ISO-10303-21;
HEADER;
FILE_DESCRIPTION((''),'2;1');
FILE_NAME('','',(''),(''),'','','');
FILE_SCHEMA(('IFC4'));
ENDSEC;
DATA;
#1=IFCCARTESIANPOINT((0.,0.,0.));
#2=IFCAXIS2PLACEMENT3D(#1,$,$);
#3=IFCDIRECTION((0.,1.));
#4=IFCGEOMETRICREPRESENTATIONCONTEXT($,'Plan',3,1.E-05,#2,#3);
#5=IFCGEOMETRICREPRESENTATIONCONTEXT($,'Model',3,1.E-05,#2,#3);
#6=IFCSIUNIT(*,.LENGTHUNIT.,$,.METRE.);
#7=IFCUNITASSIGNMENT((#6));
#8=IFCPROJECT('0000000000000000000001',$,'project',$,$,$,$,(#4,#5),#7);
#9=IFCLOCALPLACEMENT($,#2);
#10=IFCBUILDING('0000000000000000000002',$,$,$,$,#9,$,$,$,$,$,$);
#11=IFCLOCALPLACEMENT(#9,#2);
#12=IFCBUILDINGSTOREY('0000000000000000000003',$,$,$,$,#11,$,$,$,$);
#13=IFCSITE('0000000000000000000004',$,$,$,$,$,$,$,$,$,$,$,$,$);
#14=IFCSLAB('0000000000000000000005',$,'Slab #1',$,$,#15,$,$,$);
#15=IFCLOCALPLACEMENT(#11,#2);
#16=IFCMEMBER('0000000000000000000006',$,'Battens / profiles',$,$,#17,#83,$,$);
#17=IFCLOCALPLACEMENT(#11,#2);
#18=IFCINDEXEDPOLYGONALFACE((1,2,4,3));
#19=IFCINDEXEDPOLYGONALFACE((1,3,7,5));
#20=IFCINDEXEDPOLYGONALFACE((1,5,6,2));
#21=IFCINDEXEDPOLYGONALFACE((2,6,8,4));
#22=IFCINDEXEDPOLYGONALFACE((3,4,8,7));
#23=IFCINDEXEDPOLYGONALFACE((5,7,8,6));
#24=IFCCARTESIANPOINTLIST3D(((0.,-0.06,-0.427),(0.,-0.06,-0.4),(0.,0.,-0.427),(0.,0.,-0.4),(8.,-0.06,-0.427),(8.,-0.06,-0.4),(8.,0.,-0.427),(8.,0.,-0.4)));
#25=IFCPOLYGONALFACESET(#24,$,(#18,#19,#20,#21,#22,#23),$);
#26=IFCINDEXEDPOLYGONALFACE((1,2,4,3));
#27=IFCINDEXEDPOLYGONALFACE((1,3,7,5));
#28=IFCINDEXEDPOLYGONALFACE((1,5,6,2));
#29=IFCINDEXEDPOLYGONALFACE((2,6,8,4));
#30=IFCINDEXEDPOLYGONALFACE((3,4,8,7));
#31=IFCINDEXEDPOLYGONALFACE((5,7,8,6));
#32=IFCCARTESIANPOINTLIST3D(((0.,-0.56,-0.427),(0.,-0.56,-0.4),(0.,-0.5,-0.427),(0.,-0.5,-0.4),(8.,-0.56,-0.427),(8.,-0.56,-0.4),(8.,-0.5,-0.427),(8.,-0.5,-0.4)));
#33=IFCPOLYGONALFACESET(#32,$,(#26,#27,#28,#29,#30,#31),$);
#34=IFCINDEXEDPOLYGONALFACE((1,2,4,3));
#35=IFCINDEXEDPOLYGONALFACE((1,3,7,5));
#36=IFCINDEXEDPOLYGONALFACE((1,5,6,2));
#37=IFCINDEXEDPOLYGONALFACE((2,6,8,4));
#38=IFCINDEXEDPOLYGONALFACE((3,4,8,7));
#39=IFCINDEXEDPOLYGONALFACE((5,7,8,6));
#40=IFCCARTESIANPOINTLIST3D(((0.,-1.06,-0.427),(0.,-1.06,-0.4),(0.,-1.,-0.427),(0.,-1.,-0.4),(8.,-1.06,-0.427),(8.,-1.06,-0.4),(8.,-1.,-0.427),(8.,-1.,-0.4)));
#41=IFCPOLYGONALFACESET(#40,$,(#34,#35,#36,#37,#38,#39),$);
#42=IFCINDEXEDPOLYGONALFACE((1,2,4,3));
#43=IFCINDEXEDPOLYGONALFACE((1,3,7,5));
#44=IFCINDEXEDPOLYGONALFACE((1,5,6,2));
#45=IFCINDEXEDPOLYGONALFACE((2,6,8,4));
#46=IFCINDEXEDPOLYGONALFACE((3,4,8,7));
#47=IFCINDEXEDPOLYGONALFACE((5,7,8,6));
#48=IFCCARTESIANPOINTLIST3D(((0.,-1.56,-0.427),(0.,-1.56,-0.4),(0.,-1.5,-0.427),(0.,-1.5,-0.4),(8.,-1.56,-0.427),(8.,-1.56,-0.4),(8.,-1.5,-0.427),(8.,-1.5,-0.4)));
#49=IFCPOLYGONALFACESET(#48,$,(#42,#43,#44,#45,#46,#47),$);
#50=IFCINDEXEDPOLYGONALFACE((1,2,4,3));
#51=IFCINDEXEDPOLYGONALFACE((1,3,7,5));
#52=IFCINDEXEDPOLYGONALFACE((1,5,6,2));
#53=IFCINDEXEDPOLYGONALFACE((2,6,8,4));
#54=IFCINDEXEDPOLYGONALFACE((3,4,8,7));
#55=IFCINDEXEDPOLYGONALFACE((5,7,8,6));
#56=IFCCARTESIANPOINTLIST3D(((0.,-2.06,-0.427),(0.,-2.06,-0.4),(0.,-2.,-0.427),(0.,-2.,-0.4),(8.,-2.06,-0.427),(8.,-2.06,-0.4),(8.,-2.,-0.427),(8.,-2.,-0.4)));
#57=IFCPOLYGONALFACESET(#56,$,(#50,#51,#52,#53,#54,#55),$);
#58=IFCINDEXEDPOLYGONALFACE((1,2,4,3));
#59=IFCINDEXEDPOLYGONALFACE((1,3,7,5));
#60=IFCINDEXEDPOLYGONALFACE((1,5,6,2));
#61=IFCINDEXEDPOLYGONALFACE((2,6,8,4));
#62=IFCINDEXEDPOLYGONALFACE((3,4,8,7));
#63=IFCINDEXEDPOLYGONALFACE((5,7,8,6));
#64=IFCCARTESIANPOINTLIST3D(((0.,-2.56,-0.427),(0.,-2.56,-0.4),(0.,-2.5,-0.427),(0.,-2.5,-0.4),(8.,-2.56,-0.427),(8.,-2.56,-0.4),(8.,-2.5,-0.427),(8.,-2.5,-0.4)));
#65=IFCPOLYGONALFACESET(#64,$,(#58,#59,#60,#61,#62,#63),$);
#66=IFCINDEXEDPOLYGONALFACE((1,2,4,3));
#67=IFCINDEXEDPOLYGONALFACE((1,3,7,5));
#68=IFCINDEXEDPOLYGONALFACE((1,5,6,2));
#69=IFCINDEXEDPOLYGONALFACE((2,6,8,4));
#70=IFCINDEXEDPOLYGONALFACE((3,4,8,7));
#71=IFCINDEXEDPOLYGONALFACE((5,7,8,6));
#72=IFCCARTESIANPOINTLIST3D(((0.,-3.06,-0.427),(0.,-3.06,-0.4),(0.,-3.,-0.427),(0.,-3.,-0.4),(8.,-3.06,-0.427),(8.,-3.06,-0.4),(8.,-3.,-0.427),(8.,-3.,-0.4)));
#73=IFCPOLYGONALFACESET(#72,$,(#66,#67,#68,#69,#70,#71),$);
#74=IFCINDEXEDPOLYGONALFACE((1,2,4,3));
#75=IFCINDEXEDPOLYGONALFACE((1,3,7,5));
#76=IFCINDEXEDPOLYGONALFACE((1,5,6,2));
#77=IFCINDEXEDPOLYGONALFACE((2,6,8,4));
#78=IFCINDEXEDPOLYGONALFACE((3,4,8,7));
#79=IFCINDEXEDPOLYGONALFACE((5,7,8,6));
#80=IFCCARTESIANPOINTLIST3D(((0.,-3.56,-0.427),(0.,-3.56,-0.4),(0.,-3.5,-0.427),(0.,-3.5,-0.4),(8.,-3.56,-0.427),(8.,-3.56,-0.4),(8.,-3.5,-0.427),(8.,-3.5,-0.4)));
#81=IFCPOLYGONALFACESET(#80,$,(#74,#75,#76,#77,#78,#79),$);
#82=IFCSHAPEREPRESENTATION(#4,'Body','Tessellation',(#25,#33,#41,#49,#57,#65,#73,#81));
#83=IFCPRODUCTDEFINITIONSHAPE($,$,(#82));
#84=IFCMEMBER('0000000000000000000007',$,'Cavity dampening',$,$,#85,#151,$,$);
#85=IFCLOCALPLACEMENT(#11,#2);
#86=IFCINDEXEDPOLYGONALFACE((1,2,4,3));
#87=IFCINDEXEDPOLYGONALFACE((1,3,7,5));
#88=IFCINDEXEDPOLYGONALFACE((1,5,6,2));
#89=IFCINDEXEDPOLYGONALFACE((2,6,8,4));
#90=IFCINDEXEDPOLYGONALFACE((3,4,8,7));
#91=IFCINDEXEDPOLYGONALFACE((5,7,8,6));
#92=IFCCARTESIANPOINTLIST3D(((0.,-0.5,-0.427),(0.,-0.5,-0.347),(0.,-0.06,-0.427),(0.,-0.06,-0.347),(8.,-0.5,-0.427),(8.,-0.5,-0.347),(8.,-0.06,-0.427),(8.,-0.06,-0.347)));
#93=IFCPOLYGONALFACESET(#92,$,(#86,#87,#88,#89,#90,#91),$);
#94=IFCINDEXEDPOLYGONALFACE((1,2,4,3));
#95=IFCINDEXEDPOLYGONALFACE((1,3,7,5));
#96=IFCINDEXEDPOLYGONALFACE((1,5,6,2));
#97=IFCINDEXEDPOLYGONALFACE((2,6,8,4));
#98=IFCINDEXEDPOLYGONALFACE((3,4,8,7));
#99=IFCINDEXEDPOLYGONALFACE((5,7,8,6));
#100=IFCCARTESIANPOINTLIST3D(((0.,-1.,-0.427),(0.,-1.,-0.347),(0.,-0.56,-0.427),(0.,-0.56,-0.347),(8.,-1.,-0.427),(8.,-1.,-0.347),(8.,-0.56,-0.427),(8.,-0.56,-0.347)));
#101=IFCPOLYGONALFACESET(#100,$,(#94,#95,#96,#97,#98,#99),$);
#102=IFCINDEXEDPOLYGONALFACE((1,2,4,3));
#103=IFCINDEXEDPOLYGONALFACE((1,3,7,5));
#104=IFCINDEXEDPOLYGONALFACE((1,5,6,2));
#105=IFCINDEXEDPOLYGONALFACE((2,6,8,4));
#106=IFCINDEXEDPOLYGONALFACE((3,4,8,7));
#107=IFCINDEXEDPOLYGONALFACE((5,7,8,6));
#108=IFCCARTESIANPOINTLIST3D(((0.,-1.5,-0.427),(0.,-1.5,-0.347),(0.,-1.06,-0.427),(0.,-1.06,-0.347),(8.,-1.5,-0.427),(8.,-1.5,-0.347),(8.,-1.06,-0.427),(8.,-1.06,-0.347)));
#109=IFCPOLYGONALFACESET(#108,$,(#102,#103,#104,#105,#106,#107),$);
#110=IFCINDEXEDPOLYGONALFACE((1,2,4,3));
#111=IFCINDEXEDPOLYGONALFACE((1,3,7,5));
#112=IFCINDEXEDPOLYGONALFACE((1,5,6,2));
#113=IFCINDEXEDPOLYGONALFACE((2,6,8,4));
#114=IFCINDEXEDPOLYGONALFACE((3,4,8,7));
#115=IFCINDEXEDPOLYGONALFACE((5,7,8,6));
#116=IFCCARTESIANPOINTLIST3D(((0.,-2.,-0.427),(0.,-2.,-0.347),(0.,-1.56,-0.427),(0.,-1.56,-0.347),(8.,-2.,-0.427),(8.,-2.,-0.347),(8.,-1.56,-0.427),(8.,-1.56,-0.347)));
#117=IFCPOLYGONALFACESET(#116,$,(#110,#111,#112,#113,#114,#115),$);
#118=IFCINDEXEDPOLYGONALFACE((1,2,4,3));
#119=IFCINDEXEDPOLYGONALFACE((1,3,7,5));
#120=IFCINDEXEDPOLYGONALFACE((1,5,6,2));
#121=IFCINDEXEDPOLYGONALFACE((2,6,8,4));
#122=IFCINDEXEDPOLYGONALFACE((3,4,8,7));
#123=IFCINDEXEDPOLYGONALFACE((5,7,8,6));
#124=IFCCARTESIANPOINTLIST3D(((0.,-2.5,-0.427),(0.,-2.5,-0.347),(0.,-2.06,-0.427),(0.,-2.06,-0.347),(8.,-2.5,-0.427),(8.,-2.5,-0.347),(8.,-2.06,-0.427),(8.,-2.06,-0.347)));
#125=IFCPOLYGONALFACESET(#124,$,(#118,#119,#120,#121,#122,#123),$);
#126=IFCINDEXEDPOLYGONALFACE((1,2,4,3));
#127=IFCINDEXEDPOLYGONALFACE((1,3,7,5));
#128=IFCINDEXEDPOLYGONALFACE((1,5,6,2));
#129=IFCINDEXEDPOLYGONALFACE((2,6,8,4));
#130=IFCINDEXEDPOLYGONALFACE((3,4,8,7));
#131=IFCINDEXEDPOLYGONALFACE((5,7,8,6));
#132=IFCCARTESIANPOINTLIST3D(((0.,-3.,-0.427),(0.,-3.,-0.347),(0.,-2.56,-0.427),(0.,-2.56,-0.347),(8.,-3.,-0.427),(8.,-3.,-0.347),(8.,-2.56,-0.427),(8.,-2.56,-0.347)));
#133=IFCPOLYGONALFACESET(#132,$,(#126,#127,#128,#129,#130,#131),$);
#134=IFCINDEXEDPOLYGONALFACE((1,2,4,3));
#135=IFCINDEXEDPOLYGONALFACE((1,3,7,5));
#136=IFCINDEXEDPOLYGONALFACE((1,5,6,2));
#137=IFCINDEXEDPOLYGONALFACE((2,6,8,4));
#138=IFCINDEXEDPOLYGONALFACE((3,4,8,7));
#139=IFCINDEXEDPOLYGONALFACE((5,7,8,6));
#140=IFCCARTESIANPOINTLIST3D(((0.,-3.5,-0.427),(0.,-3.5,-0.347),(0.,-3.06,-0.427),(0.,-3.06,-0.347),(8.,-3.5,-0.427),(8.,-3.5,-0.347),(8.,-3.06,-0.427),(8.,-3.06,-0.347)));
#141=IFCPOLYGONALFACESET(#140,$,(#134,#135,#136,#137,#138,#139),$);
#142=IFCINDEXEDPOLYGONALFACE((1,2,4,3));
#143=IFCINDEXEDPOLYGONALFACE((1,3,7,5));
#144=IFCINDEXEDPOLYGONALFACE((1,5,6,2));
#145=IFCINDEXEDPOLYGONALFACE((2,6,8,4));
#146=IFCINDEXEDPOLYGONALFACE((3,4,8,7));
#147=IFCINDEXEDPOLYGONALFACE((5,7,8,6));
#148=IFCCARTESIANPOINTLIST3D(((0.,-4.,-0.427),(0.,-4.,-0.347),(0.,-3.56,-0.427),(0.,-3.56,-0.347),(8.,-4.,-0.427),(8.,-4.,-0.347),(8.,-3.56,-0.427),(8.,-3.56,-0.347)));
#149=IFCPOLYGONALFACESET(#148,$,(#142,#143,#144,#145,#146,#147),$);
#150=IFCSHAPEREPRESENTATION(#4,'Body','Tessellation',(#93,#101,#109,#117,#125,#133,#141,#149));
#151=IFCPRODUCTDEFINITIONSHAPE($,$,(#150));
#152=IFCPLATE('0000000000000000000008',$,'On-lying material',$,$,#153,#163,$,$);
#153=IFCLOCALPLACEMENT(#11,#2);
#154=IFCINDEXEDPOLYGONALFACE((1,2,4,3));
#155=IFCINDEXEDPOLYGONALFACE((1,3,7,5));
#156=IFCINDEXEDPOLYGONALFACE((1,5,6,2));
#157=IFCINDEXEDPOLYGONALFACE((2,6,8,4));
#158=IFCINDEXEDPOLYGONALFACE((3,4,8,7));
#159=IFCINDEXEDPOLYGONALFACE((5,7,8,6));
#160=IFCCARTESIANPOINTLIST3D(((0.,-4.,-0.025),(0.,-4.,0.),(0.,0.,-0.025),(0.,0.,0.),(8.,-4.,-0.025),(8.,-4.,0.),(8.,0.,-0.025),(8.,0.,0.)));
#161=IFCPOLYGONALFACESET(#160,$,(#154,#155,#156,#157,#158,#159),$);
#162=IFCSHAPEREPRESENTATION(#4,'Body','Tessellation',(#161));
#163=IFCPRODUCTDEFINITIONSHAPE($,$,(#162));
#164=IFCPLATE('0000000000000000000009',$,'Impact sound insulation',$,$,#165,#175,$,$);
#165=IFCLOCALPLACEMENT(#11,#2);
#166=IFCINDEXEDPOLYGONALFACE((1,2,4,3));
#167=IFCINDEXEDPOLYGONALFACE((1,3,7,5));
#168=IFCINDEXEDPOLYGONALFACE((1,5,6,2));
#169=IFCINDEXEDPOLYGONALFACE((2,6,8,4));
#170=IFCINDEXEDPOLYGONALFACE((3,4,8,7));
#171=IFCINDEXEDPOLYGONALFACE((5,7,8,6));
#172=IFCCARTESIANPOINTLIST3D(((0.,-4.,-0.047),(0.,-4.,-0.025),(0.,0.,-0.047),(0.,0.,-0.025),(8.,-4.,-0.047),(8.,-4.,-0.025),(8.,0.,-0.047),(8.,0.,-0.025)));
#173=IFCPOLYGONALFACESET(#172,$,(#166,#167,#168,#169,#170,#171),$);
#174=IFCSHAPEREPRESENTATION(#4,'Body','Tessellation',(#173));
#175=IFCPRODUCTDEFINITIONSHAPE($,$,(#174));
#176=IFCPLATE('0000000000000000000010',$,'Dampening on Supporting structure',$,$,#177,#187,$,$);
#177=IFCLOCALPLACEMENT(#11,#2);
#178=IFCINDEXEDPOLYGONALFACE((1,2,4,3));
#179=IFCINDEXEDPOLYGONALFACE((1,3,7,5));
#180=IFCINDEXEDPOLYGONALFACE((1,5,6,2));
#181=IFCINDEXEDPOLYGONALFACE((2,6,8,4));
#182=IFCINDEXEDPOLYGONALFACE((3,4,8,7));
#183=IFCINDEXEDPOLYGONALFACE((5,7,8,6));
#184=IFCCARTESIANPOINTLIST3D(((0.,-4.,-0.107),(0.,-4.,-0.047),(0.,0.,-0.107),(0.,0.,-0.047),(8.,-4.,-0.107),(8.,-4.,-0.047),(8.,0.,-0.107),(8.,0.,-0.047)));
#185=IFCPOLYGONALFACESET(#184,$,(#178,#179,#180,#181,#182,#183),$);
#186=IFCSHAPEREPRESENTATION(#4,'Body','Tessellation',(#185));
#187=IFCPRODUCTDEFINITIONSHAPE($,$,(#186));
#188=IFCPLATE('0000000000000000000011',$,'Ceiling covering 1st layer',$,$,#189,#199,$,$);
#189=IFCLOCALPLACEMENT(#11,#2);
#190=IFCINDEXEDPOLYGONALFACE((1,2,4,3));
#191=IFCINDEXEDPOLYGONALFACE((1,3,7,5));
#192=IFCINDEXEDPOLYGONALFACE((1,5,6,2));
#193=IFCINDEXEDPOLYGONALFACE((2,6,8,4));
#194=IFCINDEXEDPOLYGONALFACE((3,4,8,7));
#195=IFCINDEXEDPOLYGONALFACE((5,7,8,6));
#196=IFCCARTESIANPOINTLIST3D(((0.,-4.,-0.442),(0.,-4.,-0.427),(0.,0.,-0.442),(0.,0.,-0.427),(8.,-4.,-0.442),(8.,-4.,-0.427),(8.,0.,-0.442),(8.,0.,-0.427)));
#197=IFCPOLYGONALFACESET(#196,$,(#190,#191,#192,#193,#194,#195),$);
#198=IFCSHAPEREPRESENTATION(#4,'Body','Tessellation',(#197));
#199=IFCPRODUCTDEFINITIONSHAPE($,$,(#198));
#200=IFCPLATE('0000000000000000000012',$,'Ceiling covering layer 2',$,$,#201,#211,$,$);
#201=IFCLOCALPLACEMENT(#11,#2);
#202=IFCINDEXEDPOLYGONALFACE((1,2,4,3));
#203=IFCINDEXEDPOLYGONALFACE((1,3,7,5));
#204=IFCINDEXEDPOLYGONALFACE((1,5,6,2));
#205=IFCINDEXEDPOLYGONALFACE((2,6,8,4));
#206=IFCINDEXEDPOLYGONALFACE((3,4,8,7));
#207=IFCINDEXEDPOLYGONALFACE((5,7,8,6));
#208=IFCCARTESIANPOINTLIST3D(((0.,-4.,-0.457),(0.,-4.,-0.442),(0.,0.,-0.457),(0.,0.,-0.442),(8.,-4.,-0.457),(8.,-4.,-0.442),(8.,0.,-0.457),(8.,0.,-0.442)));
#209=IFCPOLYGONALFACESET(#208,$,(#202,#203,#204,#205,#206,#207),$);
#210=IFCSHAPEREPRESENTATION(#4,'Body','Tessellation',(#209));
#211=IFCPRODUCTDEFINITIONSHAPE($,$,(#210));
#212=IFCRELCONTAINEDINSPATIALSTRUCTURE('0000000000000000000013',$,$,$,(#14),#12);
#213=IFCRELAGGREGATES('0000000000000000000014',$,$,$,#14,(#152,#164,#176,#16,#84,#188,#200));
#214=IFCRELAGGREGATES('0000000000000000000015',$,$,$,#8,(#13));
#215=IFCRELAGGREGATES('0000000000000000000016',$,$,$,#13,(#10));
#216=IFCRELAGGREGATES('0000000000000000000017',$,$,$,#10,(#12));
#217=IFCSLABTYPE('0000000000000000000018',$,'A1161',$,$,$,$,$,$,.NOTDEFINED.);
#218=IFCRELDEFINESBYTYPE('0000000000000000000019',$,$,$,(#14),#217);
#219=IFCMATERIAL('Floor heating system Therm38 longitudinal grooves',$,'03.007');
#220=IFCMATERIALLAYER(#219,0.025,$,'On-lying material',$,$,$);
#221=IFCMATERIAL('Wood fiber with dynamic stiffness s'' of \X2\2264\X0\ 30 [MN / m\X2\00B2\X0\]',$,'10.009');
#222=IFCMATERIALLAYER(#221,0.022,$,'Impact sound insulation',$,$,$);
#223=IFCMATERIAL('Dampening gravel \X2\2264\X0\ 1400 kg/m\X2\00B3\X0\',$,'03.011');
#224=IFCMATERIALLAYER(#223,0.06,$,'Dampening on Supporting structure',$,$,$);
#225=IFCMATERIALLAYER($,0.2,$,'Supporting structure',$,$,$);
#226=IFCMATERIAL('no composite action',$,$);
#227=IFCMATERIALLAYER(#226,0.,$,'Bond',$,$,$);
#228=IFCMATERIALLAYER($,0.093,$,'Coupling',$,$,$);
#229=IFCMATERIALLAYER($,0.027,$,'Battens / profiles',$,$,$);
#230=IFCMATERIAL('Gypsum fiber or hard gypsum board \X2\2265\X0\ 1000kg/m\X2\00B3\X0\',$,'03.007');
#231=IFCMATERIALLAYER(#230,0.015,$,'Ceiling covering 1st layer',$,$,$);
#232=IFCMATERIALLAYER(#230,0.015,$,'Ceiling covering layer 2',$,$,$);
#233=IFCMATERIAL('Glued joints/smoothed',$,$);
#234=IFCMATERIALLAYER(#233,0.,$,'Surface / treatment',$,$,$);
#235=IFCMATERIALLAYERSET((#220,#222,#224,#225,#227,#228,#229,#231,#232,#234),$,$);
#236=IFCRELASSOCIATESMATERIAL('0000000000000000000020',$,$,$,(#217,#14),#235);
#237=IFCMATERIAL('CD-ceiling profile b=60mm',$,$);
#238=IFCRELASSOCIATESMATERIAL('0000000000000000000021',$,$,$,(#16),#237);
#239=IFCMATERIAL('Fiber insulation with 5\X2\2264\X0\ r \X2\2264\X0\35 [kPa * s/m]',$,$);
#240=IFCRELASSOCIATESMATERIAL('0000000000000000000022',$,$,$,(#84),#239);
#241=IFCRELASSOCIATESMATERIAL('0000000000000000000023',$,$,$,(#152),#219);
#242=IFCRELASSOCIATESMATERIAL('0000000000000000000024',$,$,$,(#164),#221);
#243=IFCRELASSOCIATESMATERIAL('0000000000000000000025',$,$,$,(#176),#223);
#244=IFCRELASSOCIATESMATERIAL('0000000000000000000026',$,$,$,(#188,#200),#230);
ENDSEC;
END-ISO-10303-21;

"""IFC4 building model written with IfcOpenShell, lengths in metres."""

from ifc_helpers import new_model, si_unit, direction, frame, frame_2d, origin, origin_with_axes, place, context, project, spatial, rectangle, extrude, material, layer, layer_set, type_object, element, aggregate, save


model = new_model("IFC4")

# Units and contexts
plan_context = context("Plan", 3, precision=1e-05, world=origin(), true_north=direction((0.0, 1.0)))
model_context = context("Model", 3, precision=1e-05, world=origin(), true_north=direction((0.0, 1.0)))
ifc_project = project(units=[si_unit("LENGTHUNIT", "METRE")], contexts=[plan_context, model_context])

# Site, building, storey
site = spatial("IfcSite", under=ifc_project)
building_placement = place(None, origin())
building = spatial("IfcBuilding", under=site, at=building_placement)
storey_placement = place(building_placement, origin())
storey = spatial("IfcBuildingStorey", under=building, at=storey_placement)

# Slab, members, plates
ifc_material_1 = material(Name="Floor heating system Therm38 longitudinal grooves", Category="03.007")
ifc_layer_1 = layer(ifc_material_1, 0.025, Name="On-lying material")
ifc_material_2 = material(Name="Wood fiber with dynamic stiffness s' of ≤ 30 [MN / m²]", Category="10.009")
ifc_layer_2 = layer(ifc_material_2, 0.022, Name="Impact sound insulation")
ifc_material_3 = material(Name="Dampening gravel ≤ 1400 kg/m³", Category="03.011")
ifc_layer_3 = layer(ifc_material_3, 0.06, Name="Dampening on Supporting structure")
ifc_layer_4 = layer(None, 0.2, Name="Supporting structure")
ifc_material_4 = material(Name="no composite action")
ifc_layer_5 = layer(ifc_material_4, 0.0, Name="Bond")
ifc_layer_6 = layer(None, 0.093, Name="Coupling")
ifc_layer_7 = layer(None, 0.027, Name="Battens / profiles")
ifc_material_5 = material(Name="Gypsum fiber or hard gypsum board ≥ 1000kg/m³", Category="03.007")
ifc_layer_8 = layer(ifc_material_5, 0.015, Name="Ceiling covering 1st layer")
ifc_layer_9 = layer(ifc_material_5, 0.015, Name="Ceiling covering layer 2")
ifc_material_6 = material(Name="Glued joints/smoothed")
ifc_layer_10 = layer(ifc_material_6, 0.0, Name="Surface / treatment")
ifc_layer_set = layer_set([ifc_layer_1, ifc_layer_2, ifc_layer_3, ifc_layer_4, ifc_layer_5, ifc_layer_6, ifc_layer_7, ifc_layer_8, ifc_layer_9, ifc_layer_10])
slab_type = type_object("IfcSlabType", Name="A1161", PredefinedType="NOTDEFINED", material=ifc_layer_set)
slab_placement = place(None, frame((0.0, 0.0, 0.0), z_axis=(0.0, 0.0, -1.0), x_axis=(1.0, 0.0, 0.0)))
slab = element("IfcSlab", 1, at=slab_placement, inside=storey, type_object=slab_type, material=ifc_layer_set, Name="Slab #1")
ifc_material_7 = material(Name="CD-ceiling profile b=60mm")
member_1_placement = place(slab_placement, origin())
member_1 = element("IfcMember", 2, at=member_1_placement, material=ifc_material_7, Name="Battens / profiles", context=plan_context, shape_type="SweptSolid", body=[
    extrude(rectangle(XDim=0.06, YDim=0.027, at=frame_2d((0.03, 0.0135), x_axis=(1.0, 0.0))), frame((0.0, 0.0, 0.4), z_axis=(1.0, 0.0, 0.0), x_axis=(0.0, 1.0, 0.0)), (0.0, 0.0, 1.0), 8.0),
    extrude(rectangle(XDim=0.06, YDim=0.027, at=frame_2d((0.03, 0.0135), x_axis=(1.0, 0.0))), frame((0.0, 0.5, 0.4), z_axis=(1.0, 0.0, 0.0), x_axis=(0.0, 1.0, 0.0)), (0.0, 0.0, 1.0), 8.0),
    extrude(rectangle(XDim=0.06, YDim=0.027, at=frame_2d((0.03, 0.0135), x_axis=(1.0, 0.0))), frame((0.0, 1.0, 0.4), z_axis=(1.0, 0.0, 0.0), x_axis=(0.0, 1.0, 0.0)), (0.0, 0.0, 1.0), 8.0),
    extrude(rectangle(XDim=0.06, YDim=0.027, at=frame_2d((0.03, 0.0135), x_axis=(1.0, 0.0))), frame((0.0, 1.5, 0.4), z_axis=(1.0, 0.0, 0.0), x_axis=(0.0, 1.0, 0.0)), (0.0, 0.0, 1.0), 8.0),
    extrude(rectangle(XDim=0.06, YDim=0.027, at=frame_2d((0.03, 0.0135), x_axis=(1.0, 0.0))), frame((0.0, 2.0, 0.4), z_axis=(1.0, 0.0, 0.0), x_axis=(0.0, 1.0, 0.0)), (0.0, 0.0, 1.0), 8.0),
    extrude(rectangle(XDim=0.06, YDim=0.027, at=frame_2d((0.03, 0.0135), x_axis=(1.0, 0.0))), frame((0.0, 2.5, 0.4), z_axis=(1.0, 0.0, 0.0), x_axis=(0.0, 1.0, 0.0)), (0.0, 0.0, 1.0), 8.0),
    extrude(rectangle(XDim=0.06, YDim=0.027, at=frame_2d((0.03, 0.0135), x_axis=(1.0, 0.0))), frame((0.0, 3.0, 0.4), z_axis=(1.0, 0.0, 0.0), x_axis=(0.0, 1.0, 0.0)), (0.0, 0.0, 1.0), 8.0),
    extrude(rectangle(XDim=0.06, YDim=0.027, at=frame_2d((0.03, 0.0135), x_axis=(1.0, 0.0))), frame((0.0, 3.5, 0.4), z_axis=(1.0, 0.0, 0.0), x_axis=(0.0, 1.0, 0.0)), (0.0, 0.0, 1.0), 8.0),
])
ifc_material_8 = material(Name="Fiber insulation with 5≤ r ≤35 [kPa * s/m]")
member_2_placement = place(slab_placement, origin())
member_2 = element("IfcMember", 3, at=member_2_placement, material=ifc_material_8, Name="Cavity dampening", context=plan_context, shape_type="SweptSolid", body=[
    extrude(rectangle(XDim=0.44, YDim=0.08, at=frame_2d((0.22, 0.04), x_axis=(1.0, 0.0))), frame((0.0, 0.06, 0.347), z_axis=(1.0, 0.0, 0.0), x_axis=(0.0, 1.0, 0.0)), (0.0, 0.0, 1.0), 8.0),
    extrude(rectangle(XDim=0.44, YDim=0.08, at=frame_2d((0.22, 0.04), x_axis=(1.0, 0.0))), frame((0.0, 0.56, 0.347), z_axis=(1.0, 0.0, 0.0), x_axis=(0.0, 1.0, 0.0)), (0.0, 0.0, 1.0), 8.0),
    extrude(rectangle(XDim=0.44, YDim=0.08, at=frame_2d((0.22, 0.04), x_axis=(1.0, 0.0))), frame((0.0, 1.06, 0.347), z_axis=(1.0, 0.0, 0.0), x_axis=(0.0, 1.0, 0.0)), (0.0, 0.0, 1.0), 8.0),
    extrude(rectangle(XDim=0.44, YDim=0.08, at=frame_2d((0.22, 0.04), x_axis=(1.0, 0.0))), frame((0.0, 1.56, 0.347), z_axis=(1.0, 0.0, 0.0), x_axis=(0.0, 1.0, 0.0)), (0.0, 0.0, 1.0), 8.0),
    extrude(rectangle(XDim=0.44, YDim=0.08, at=frame_2d((0.22, 0.04), x_axis=(1.0, 0.0))), frame((0.0, 2.06, 0.347), z_axis=(1.0, 0.0, 0.0), x_axis=(0.0, 1.0, 0.0)), (0.0, 0.0, 1.0), 8.0),
    extrude(rectangle(XDim=0.44, YDim=0.08, at=frame_2d((0.22, 0.04), x_axis=(1.0, 0.0))), frame((0.0, 2.56, 0.347), z_axis=(1.0, 0.0, 0.0), x_axis=(0.0, 1.0, 0.0)), (0.0, 0.0, 1.0), 8.0),
    extrude(rectangle(XDim=0.44, YDim=0.08, at=frame_2d((0.22, 0.04), x_axis=(1.0, 0.0))), frame((0.0, 3.06, 0.347), z_axis=(1.0, 0.0, 0.0), x_axis=(0.0, 1.0, 0.0)), (0.0, 0.0, 1.0), 8.0),
    extrude(rectangle(XDim=0.44, YDim=0.08, at=frame_2d((0.22, 0.04), x_axis=(1.0, 0.0))), frame((0.0, 3.56, 0.347), z_axis=(1.0, 0.0, 0.0), x_axis=(0.0, 1.0, 0.0)), (0.0, 0.0, 1.0), 8.0),
])
plate_1_placement = place(slab_placement, origin())
plate_1 = element("IfcPlate", 4, at=plate_1_placement, material=ifc_material_1, Name="On-lying material", context=plan_context, shape_type="SweptSolid", body=[
    extrude(rectangle(XDim=8.0, YDim=4.0, at=frame_2d((4.0, 2.0), x_axis=(1.0, 0.0))), origin_with_axes(), (0.0, 0.0, 1.0), 0.025),
])
plate_2_placement = place(slab_placement, origin())
plate_2 = element("IfcPlate", 5, at=plate_2_placement, material=ifc_material_2, Name="Impact sound insulation", context=plan_context, shape_type="SweptSolid", body=[
    extrude(rectangle(XDim=8.0, YDim=4.0, at=frame_2d((4.0, 2.0), x_axis=(1.0, 0.0))), frame((0.0, 0.0, 0.025), z_axis=(0.0, 0.0, 1.0), x_axis=(1.0, 0.0, 0.0)), (0.0, 0.0, 1.0), 0.022),
])
plate_3_placement = place(slab_placement, origin())
plate_3 = element("IfcPlate", 6, at=plate_3_placement, material=ifc_material_3, Name="Dampening on Supporting structure", context=plan_context, shape_type="SweptSolid", body=[
    extrude(rectangle(XDim=8.0, YDim=4.0, at=frame_2d((4.0, 2.0), x_axis=(1.0, 0.0))), frame((0.0, 0.0, 0.047), z_axis=(0.0, 0.0, 1.0), x_axis=(1.0, 0.0, 0.0)), (0.0, 0.0, 1.0), 0.06),
])
plate_4_placement = place(slab_placement, origin())
plate_4 = element("IfcPlate", 7, at=plate_4_placement, material=ifc_material_5, Name="Ceiling covering 1st layer", context=plan_context, shape_type="SweptSolid", body=[
    extrude(rectangle(XDim=8.0, YDim=4.0, at=frame_2d((4.0, 2.0), x_axis=(1.0, 0.0))), frame((0.0, 0.0, 0.427), z_axis=(0.0, 0.0, 1.0), x_axis=(1.0, 0.0, 0.0)), (0.0, 0.0, 1.0), 0.015),
])
plate_5_placement = place(slab_placement, origin())
plate_5 = element("IfcPlate", 8, at=plate_5_placement, material=ifc_material_5, Name="Ceiling covering layer 2", context=plan_context, shape_type="SweptSolid", body=[
    extrude(rectangle(XDim=8.0, YDim=4.0, at=frame_2d((4.0, 2.0), x_axis=(1.0, 0.0))), frame((0.0, 0.0, 0.442), z_axis=(0.0, 0.0, 1.0), x_axis=(1.0, 0.0, 0.0)), (0.0, 0.0, 1.0), 0.015),
])
aggregate(slab, [plate_1, plate_2, plate_3, member_1, member_2, plate_4, plate_5])

save(model, "model.ifc")
